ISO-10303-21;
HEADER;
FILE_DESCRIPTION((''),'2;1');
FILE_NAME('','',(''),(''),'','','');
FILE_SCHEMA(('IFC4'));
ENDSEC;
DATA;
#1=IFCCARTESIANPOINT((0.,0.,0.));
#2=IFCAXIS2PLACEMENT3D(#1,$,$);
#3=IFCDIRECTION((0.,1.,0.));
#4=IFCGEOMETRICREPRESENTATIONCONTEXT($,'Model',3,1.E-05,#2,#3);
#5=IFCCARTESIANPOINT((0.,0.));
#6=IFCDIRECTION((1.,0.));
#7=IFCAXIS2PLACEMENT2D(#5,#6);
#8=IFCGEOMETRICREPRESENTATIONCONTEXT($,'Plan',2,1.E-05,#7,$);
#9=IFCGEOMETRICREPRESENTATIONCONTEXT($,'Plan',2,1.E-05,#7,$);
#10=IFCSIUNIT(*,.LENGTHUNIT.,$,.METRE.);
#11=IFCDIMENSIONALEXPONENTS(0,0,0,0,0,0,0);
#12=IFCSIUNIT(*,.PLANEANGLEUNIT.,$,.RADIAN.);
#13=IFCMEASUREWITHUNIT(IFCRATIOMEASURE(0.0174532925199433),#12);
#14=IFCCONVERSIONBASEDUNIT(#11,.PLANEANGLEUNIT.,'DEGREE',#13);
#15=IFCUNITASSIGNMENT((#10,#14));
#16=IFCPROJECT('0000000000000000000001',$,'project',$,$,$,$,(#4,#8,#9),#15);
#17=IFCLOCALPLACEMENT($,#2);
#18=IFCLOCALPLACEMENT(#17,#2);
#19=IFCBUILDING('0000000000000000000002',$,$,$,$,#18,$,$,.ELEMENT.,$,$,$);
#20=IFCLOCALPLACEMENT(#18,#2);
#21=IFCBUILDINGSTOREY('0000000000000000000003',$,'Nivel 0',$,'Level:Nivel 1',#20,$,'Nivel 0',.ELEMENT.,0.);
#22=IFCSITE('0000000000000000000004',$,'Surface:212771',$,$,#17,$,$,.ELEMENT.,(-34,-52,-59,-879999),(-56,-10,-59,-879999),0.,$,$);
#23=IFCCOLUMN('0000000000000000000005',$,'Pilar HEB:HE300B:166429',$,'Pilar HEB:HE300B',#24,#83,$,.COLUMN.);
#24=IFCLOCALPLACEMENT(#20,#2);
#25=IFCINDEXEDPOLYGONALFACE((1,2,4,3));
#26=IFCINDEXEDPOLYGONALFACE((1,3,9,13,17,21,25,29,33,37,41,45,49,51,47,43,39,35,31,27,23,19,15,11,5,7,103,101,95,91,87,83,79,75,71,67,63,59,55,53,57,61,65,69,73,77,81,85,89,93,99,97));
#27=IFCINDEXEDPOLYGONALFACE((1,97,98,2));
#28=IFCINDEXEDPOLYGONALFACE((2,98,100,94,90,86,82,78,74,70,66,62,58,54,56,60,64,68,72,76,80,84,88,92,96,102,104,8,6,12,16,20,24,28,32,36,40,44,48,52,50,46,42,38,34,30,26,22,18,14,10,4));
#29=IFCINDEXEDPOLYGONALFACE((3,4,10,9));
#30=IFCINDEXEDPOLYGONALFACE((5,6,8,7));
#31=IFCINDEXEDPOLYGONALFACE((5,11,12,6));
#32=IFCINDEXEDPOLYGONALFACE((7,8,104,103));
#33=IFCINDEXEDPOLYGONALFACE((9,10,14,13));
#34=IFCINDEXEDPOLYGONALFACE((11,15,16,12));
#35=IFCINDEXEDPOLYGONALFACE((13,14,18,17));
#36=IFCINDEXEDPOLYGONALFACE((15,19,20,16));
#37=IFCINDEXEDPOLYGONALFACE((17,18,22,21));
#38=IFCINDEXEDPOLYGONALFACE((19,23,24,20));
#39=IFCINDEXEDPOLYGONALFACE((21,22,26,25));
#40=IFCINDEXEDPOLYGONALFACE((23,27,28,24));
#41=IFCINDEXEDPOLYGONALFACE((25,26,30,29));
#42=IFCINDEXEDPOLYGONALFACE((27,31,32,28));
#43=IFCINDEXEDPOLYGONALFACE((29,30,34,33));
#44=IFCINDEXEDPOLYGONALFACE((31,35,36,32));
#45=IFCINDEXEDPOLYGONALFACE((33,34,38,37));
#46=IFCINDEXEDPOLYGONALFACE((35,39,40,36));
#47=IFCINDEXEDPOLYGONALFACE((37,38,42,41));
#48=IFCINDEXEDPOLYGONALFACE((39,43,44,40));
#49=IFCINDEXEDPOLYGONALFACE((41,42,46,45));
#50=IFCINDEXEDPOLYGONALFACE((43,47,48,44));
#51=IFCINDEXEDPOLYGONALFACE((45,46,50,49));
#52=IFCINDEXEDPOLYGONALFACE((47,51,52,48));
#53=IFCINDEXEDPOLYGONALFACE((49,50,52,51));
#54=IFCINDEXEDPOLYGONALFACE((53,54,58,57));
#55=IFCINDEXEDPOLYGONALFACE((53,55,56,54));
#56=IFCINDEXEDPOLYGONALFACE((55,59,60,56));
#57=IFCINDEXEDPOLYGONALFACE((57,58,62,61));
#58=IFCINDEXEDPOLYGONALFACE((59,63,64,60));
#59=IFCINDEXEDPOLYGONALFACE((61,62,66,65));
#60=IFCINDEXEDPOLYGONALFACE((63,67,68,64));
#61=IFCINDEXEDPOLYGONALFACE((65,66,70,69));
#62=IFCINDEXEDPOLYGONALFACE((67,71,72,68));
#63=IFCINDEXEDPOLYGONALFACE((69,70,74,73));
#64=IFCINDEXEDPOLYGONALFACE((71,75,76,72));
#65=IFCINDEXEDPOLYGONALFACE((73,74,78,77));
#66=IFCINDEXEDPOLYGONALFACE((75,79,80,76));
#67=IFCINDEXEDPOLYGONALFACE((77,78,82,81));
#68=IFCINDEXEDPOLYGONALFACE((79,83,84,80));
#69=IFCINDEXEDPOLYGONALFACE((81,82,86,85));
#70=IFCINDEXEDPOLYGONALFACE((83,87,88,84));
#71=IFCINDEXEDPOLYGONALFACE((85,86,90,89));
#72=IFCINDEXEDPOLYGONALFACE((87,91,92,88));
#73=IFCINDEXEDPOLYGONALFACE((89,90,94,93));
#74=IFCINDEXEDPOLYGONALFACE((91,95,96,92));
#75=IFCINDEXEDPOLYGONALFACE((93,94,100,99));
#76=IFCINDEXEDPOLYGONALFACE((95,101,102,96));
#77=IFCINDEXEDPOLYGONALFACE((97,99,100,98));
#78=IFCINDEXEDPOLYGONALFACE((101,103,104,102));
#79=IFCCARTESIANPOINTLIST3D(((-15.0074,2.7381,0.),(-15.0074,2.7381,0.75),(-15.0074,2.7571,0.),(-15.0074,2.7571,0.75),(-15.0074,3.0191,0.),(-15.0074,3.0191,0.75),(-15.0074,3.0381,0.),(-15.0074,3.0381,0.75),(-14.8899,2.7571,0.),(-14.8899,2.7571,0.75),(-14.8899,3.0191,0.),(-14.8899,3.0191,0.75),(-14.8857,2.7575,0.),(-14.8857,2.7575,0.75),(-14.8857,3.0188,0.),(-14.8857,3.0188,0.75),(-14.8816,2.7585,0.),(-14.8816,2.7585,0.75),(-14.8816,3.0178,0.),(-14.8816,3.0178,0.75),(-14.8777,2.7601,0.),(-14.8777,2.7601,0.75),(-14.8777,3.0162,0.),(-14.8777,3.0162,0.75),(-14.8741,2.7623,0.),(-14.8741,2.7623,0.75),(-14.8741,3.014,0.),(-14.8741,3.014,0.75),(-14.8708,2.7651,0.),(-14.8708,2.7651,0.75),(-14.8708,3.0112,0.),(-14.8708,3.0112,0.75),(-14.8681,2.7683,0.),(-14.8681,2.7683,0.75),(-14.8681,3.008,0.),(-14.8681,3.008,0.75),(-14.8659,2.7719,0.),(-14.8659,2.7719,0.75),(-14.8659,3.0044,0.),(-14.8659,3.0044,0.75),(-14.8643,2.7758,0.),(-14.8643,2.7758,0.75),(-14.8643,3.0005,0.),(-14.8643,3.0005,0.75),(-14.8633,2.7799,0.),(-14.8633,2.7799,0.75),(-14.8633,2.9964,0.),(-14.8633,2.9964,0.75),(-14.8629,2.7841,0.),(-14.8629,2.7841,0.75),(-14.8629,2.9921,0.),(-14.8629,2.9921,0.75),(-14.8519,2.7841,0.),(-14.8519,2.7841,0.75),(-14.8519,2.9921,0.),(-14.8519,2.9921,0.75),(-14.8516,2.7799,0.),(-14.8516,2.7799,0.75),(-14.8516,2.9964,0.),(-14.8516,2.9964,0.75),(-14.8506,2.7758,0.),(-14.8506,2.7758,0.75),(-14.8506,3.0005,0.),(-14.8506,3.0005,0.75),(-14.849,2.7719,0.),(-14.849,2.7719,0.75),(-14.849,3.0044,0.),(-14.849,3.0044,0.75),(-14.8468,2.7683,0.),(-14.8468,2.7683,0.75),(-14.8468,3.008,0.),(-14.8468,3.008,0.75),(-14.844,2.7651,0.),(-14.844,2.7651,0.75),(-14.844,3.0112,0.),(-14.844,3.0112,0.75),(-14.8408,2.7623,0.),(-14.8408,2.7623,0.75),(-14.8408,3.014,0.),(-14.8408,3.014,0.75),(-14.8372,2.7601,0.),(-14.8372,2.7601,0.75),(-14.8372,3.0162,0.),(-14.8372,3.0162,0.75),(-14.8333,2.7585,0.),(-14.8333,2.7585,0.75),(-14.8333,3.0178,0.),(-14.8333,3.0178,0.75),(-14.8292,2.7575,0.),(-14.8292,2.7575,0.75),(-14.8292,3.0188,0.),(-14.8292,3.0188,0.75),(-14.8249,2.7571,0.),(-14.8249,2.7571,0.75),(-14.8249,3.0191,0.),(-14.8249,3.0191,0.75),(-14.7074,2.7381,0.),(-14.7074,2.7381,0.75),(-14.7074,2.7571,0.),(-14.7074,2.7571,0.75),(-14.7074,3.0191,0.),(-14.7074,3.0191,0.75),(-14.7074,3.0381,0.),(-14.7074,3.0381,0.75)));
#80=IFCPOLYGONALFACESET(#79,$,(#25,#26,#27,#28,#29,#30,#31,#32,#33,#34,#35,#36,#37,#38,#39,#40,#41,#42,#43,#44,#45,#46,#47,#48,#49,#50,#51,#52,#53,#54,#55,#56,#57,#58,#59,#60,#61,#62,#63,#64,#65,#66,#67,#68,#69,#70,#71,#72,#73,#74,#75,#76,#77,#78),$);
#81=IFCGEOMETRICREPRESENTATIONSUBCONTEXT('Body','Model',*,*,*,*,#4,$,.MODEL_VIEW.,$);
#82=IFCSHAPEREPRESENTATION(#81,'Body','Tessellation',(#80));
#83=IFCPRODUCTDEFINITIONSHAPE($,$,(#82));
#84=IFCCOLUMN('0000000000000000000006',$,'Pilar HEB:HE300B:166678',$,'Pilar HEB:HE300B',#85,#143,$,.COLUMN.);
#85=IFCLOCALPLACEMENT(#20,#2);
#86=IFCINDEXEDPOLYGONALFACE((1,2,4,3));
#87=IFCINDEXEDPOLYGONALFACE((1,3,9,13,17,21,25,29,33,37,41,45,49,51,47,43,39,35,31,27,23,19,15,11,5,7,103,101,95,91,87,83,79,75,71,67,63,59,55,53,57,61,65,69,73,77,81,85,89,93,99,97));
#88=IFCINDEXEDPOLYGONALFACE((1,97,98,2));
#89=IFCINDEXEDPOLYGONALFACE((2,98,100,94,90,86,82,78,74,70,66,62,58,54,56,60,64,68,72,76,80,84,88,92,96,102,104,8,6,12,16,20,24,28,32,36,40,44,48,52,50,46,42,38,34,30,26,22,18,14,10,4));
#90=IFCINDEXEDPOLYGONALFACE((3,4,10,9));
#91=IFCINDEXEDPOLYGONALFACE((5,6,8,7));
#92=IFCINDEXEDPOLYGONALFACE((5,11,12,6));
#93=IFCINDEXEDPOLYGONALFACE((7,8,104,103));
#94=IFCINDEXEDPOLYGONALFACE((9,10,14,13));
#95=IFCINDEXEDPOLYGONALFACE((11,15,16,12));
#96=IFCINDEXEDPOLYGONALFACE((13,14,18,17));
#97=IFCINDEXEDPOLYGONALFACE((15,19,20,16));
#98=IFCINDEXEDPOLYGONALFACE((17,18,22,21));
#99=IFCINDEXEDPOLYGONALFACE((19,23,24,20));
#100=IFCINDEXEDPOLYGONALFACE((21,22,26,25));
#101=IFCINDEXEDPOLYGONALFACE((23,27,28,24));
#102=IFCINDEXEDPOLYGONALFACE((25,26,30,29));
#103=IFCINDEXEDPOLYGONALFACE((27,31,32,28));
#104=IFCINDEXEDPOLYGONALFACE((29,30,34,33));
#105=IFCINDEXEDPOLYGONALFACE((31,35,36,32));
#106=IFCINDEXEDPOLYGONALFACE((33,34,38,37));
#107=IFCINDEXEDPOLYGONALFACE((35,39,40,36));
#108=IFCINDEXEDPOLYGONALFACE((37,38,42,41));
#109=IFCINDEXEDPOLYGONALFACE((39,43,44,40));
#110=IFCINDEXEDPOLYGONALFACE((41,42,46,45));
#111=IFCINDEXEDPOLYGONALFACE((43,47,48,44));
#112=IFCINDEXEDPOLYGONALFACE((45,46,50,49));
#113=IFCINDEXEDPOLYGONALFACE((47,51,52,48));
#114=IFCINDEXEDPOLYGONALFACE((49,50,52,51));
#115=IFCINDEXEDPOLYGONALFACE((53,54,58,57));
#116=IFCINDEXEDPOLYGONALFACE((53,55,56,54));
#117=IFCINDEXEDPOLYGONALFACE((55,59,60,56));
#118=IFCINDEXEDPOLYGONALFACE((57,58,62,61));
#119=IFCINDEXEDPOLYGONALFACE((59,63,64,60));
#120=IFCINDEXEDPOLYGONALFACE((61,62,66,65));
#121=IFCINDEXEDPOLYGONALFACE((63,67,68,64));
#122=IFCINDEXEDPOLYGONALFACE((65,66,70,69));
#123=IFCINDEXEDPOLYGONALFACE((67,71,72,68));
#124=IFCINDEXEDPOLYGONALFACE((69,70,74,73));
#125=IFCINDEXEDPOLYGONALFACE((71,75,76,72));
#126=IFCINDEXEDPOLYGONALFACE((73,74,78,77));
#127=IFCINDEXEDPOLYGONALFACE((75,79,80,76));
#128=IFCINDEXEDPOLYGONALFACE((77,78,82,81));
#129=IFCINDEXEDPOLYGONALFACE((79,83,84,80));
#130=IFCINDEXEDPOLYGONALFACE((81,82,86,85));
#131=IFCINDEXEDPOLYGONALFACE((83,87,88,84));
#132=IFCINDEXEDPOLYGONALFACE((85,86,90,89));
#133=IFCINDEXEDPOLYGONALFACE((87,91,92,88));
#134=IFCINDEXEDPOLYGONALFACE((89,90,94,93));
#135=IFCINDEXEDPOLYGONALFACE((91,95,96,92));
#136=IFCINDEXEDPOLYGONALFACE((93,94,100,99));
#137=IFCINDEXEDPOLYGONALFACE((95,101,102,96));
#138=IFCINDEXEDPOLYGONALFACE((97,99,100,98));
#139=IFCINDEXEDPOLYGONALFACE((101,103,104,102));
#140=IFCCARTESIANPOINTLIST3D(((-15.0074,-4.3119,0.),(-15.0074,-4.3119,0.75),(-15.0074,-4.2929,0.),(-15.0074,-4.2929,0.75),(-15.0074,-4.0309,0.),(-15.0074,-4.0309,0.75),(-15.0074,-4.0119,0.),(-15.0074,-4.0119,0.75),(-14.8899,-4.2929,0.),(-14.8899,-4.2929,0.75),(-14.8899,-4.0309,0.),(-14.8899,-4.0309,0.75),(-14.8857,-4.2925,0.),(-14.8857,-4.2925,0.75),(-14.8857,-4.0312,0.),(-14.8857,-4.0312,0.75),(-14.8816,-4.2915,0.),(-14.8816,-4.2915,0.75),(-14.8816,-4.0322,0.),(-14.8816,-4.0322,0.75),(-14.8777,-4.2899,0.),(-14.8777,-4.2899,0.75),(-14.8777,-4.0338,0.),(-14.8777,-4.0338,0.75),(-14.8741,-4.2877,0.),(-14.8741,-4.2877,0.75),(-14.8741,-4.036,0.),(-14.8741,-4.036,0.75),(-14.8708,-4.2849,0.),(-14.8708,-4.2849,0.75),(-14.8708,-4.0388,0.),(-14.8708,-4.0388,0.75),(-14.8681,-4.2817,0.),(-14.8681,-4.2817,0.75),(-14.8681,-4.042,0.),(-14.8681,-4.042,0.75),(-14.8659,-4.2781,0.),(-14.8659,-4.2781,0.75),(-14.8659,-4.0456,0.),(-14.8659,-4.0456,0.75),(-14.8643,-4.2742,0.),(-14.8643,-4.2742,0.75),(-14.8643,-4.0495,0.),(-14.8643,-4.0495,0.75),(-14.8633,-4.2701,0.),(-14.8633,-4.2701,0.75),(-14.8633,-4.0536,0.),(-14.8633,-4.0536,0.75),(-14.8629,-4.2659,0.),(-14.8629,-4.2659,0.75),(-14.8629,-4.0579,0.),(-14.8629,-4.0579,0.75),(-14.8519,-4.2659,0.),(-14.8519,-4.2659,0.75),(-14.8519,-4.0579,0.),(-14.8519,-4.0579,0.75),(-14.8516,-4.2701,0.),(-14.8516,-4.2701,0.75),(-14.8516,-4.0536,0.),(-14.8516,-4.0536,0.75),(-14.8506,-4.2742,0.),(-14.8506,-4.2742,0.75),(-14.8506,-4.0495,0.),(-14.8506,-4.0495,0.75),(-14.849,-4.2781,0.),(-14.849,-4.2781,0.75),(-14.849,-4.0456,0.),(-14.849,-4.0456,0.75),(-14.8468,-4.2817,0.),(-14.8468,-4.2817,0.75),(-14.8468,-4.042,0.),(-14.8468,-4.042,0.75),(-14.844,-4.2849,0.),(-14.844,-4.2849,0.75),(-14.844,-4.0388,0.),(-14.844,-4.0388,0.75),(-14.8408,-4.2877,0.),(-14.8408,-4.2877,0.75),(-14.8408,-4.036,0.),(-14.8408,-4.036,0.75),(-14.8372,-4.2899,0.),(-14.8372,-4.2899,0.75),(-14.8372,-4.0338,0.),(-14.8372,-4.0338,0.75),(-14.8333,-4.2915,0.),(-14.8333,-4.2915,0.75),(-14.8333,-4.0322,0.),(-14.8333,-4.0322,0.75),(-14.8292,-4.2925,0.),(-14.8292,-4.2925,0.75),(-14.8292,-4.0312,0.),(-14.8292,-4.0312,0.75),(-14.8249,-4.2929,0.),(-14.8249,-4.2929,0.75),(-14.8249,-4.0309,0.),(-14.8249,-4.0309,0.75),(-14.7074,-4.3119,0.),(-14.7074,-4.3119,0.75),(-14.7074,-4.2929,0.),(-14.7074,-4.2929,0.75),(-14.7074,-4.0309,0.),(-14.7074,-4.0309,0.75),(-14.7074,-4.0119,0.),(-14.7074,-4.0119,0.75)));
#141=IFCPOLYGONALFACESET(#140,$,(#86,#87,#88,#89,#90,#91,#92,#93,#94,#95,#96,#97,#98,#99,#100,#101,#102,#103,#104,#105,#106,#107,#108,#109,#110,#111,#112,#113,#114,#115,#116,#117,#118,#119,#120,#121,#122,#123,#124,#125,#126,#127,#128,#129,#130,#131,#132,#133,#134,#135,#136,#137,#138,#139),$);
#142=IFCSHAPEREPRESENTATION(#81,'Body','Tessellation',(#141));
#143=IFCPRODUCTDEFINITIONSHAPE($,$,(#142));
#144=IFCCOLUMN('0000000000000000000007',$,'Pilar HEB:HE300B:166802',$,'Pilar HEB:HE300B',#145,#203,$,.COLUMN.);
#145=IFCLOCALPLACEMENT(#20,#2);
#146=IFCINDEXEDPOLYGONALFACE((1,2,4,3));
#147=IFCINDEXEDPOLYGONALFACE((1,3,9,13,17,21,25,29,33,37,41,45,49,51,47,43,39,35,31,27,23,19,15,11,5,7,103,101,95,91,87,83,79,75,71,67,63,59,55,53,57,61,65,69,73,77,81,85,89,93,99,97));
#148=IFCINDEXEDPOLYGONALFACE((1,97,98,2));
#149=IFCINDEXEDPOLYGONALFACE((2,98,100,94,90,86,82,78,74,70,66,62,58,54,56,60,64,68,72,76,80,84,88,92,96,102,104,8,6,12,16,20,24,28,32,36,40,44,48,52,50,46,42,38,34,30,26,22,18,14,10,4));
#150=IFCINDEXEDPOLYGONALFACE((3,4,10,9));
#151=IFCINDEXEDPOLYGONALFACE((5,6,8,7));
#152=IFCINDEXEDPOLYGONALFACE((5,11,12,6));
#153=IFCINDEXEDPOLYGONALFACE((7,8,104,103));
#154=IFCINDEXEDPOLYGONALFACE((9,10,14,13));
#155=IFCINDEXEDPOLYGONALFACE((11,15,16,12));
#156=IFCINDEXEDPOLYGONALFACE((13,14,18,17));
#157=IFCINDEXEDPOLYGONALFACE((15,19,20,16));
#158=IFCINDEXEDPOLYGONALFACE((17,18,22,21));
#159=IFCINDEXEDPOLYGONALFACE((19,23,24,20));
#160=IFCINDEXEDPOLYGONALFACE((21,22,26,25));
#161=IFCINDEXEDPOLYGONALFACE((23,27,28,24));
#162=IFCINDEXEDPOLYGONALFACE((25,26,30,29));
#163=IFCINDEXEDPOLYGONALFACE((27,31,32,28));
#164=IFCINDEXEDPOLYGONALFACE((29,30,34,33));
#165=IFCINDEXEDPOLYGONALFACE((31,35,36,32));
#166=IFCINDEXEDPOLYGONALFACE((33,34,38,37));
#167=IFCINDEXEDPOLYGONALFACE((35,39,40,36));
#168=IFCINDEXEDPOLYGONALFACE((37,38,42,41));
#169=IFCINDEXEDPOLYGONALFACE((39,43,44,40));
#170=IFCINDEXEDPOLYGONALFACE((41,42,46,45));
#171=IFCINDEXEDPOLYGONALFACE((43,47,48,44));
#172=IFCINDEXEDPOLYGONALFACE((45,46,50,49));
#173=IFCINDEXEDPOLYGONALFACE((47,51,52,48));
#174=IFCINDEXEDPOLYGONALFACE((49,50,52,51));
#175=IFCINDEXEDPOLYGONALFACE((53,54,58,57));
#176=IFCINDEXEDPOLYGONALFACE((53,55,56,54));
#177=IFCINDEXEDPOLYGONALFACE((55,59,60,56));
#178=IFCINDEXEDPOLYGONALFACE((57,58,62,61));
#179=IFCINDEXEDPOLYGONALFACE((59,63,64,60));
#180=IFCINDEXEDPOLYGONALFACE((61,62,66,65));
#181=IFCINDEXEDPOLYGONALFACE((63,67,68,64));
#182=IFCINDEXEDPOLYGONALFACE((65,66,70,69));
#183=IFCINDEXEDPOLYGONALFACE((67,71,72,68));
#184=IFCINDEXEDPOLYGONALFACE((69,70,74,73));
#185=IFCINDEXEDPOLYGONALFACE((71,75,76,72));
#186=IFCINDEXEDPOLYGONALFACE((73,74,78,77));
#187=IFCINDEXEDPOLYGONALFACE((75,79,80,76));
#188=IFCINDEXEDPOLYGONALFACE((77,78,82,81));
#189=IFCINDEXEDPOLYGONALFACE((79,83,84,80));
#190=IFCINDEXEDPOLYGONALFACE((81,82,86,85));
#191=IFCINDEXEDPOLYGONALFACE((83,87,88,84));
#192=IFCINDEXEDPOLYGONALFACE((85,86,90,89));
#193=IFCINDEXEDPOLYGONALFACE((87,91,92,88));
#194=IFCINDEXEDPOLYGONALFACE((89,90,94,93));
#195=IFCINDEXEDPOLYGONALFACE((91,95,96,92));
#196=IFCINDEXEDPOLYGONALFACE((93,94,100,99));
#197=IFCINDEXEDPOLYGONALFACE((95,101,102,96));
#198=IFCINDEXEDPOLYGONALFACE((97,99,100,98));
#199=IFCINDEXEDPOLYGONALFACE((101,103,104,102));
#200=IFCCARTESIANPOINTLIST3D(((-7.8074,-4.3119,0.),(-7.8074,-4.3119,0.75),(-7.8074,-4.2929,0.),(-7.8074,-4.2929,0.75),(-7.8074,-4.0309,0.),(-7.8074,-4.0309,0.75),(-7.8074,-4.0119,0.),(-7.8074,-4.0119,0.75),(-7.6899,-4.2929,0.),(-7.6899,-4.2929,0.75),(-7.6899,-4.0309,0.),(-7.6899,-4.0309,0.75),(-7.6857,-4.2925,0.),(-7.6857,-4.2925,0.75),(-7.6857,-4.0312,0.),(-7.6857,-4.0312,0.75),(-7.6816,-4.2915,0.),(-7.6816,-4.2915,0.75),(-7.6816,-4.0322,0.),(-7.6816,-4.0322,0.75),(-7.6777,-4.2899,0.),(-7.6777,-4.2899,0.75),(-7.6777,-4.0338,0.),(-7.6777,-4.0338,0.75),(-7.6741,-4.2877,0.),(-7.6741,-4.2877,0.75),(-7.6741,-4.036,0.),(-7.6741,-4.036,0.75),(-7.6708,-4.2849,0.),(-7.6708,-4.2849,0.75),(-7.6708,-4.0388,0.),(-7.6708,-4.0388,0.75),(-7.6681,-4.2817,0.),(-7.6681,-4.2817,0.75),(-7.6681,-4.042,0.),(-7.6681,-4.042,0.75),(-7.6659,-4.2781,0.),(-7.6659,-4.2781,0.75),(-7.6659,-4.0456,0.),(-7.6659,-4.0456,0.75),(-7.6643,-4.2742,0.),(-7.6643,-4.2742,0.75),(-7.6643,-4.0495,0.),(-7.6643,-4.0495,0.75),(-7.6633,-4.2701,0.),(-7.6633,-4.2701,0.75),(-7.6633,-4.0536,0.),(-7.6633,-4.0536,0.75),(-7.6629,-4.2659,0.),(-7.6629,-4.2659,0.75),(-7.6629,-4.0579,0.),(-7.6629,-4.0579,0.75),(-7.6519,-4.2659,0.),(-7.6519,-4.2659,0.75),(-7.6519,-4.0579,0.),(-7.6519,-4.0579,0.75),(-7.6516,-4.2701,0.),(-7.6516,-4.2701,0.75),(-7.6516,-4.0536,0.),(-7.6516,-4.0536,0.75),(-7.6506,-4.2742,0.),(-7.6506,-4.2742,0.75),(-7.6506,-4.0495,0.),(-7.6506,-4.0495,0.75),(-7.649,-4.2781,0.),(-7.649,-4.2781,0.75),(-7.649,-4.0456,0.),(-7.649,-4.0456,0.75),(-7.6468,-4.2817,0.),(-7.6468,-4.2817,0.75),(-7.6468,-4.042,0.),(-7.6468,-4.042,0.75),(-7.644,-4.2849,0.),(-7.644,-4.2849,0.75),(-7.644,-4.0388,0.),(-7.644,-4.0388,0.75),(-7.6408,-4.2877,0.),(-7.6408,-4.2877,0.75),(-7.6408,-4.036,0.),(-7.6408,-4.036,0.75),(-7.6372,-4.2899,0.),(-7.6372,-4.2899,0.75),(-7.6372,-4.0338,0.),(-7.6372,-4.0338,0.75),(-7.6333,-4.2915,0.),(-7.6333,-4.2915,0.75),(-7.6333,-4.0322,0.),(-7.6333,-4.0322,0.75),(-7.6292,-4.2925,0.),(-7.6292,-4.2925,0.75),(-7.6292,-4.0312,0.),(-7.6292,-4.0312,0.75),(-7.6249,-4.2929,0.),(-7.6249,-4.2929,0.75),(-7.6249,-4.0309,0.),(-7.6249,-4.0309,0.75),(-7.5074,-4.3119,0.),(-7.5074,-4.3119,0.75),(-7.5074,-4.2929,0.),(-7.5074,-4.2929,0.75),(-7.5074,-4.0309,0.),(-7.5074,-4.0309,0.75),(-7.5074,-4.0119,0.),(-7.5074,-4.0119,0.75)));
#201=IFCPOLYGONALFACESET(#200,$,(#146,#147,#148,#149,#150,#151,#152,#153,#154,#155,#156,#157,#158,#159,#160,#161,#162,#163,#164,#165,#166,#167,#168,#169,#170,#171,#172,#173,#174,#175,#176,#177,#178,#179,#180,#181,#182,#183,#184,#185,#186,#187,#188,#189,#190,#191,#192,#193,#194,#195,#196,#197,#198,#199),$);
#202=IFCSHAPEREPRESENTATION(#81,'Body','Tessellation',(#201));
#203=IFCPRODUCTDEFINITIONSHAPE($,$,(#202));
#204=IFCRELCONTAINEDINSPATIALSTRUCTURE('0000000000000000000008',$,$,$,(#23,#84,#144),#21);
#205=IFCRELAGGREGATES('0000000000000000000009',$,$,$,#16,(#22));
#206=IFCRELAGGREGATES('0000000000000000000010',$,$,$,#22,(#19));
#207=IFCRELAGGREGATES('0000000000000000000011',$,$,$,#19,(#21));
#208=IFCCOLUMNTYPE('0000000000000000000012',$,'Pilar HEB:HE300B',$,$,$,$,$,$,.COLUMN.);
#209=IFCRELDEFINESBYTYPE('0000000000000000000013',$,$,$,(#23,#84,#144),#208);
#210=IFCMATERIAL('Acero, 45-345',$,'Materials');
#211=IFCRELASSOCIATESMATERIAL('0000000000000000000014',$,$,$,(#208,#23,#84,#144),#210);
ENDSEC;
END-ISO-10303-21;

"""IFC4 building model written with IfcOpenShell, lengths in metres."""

from ifc_helpers import new_model, entity, si_unit, converted_unit, direction, frame, origin, origin_2d_with_axis, place, context, subcontext, project, spatial, polyline, outline, extrude, source, transform, mapped, material, type_object, type_shapes, element, save


model = new_model("IFC4")

# Units and contexts
model_context = context("Model", 3, precision=1e-05, world=origin(), true_north=direction((0.0, 1.0, 0.0)))
plan_context_1 = context("Plan", 2, precision=1e-05, world=origin_2d_with_axis())
plan_context_2 = context("Plan", 2, precision=1e-05, world=origin_2d_with_axis())
body_context = subcontext(model_context, "Body", "Model", "MODEL_VIEW")
ifc_project = project(units=[si_unit("LENGTHUNIT", "METRE"), converted_unit("PLANEANGLEUNIT", "DEGREE", entity("IfcRatioMeasure", 0.0174532925199433), si_unit("PLANEANGLEUNIT", "RADIAN"), dimensions=[0, 0, 0, 0, 0, 0, 0])], contexts=[model_context, plan_context_1, plan_context_2])

# Site, building, storey
site_placement = place(None, origin())
site = spatial("IfcSite", under=ifc_project, at=site_placement, Name="Surface:212771", CompositionType="ELEMENT", RefLatitude=(-34, -52, -59, -879999), RefLongitude=(-56, -10, -59, -879999), RefElevation=0.0)
building_placement = place(site_placement, origin())
building = spatial("IfcBuilding", under=site, at=building_placement, CompositionType="ELEMENT")
storey_placement = place(building_placement, origin())
storey = spatial("IfcBuildingStorey", under=building, at=storey_placement, Name="Nivel 0", ObjectType="Level:Nivel 1", LongName="Nivel 0", CompositionType="ELEMENT", Elevation=0.0)

# Columns
ifc_material_1 = material(Name="Acero, 45-345", Category="Materials")
column_type_1 = type_object("IfcColumnType", Name="Pilar HEB:HE300B", PredefinedType="COLUMN", material=ifc_material_1)
shared_shape_1 = source(origin(), body_context, "Body", "SweptSolid", [
    extrude(outline(polyline([(-0.104, -0.0055), (0.104, -0.0055), (0.1082, -0.0058), (0.1123, -0.0068), (0.1163, -0.0084), (0.1199, -0.0107), (0.1231, -0.0134), (0.1258, -0.0166), (0.1281, -0.0202), (0.1297, -0.0242), (0.1307, -0.0283), (0.131, -0.0325), (0.131, -0.15), (0.15, -0.15), (0.15, 0.15), (0.131, 0.15), (0.131, 0.0325), (0.1307, 0.0283), (0.1297, 0.0242), (0.1281, 0.0202), (0.1258, 0.0166), (0.1231, 0.0134), (0.1199, 0.0107), (0.1163, 0.0084), (0.1123, 0.0068), (0.1082, 0.0058), (0.104, 0.0055), (-0.104, 0.0055), (-0.1082, 0.0058), (-0.1123, 0.0068), (-0.1163, 0.0084), (-0.1199, 0.0107), (-0.1231, 0.0134), (-0.1258, 0.0166), (-0.1281, 0.0202), (-0.1297, 0.0242), (-0.1307, 0.0283), (-0.131, 0.0325), (-0.131, 0.15), (-0.15, 0.15), (-0.15, -0.15), (-0.131, -0.15), (-0.131, -0.0325), (-0.1307, -0.0283), (-0.1297, -0.0242), (-0.1281, -0.0202), (-0.1258, -0.0166), (-0.1231, -0.0134), (-0.1199, -0.0107), (-0.1163, -0.0084), (-0.1123, -0.0068), (-0.1082, -0.0058), (-0.104, -0.0055)])), frame((0.0, 0.0, 0.0), z_axis=(0.0, 0.0, -1.0), x_axis=(0.0, -1.0, 0.0)), (0.0, 0.0, -1.0), 0.75),
])
type_shapes(column_type_1, [shared_shape_1])
for number, where, name in (
    (1, (-14.8574, 2.8881, 0.0), "Pilar HEB:HE300B:166429"),
    (2, (-14.8574, -4.1619, 0.0), "Pilar HEB:HE300B:166678"),
    (3, (-7.6574, -4.1619, 0.0), "Pilar HEB:HE300B:166802"),
):
    element("IfcColumn", number, at=place(storey_placement, frame(where)), inside=storey, type_object=column_type_1, material=ifc_material_1, Name=name, ObjectType="Pilar HEB:HE300B", PredefinedType="COLUMN", context=body_context, shape_type="MappedRepresentation", body=[
        mapped(shared_shape_1, transform((0.0, 0.0, 0.0), scale=1.0)),
    ])

save(model, "model.ifc")
